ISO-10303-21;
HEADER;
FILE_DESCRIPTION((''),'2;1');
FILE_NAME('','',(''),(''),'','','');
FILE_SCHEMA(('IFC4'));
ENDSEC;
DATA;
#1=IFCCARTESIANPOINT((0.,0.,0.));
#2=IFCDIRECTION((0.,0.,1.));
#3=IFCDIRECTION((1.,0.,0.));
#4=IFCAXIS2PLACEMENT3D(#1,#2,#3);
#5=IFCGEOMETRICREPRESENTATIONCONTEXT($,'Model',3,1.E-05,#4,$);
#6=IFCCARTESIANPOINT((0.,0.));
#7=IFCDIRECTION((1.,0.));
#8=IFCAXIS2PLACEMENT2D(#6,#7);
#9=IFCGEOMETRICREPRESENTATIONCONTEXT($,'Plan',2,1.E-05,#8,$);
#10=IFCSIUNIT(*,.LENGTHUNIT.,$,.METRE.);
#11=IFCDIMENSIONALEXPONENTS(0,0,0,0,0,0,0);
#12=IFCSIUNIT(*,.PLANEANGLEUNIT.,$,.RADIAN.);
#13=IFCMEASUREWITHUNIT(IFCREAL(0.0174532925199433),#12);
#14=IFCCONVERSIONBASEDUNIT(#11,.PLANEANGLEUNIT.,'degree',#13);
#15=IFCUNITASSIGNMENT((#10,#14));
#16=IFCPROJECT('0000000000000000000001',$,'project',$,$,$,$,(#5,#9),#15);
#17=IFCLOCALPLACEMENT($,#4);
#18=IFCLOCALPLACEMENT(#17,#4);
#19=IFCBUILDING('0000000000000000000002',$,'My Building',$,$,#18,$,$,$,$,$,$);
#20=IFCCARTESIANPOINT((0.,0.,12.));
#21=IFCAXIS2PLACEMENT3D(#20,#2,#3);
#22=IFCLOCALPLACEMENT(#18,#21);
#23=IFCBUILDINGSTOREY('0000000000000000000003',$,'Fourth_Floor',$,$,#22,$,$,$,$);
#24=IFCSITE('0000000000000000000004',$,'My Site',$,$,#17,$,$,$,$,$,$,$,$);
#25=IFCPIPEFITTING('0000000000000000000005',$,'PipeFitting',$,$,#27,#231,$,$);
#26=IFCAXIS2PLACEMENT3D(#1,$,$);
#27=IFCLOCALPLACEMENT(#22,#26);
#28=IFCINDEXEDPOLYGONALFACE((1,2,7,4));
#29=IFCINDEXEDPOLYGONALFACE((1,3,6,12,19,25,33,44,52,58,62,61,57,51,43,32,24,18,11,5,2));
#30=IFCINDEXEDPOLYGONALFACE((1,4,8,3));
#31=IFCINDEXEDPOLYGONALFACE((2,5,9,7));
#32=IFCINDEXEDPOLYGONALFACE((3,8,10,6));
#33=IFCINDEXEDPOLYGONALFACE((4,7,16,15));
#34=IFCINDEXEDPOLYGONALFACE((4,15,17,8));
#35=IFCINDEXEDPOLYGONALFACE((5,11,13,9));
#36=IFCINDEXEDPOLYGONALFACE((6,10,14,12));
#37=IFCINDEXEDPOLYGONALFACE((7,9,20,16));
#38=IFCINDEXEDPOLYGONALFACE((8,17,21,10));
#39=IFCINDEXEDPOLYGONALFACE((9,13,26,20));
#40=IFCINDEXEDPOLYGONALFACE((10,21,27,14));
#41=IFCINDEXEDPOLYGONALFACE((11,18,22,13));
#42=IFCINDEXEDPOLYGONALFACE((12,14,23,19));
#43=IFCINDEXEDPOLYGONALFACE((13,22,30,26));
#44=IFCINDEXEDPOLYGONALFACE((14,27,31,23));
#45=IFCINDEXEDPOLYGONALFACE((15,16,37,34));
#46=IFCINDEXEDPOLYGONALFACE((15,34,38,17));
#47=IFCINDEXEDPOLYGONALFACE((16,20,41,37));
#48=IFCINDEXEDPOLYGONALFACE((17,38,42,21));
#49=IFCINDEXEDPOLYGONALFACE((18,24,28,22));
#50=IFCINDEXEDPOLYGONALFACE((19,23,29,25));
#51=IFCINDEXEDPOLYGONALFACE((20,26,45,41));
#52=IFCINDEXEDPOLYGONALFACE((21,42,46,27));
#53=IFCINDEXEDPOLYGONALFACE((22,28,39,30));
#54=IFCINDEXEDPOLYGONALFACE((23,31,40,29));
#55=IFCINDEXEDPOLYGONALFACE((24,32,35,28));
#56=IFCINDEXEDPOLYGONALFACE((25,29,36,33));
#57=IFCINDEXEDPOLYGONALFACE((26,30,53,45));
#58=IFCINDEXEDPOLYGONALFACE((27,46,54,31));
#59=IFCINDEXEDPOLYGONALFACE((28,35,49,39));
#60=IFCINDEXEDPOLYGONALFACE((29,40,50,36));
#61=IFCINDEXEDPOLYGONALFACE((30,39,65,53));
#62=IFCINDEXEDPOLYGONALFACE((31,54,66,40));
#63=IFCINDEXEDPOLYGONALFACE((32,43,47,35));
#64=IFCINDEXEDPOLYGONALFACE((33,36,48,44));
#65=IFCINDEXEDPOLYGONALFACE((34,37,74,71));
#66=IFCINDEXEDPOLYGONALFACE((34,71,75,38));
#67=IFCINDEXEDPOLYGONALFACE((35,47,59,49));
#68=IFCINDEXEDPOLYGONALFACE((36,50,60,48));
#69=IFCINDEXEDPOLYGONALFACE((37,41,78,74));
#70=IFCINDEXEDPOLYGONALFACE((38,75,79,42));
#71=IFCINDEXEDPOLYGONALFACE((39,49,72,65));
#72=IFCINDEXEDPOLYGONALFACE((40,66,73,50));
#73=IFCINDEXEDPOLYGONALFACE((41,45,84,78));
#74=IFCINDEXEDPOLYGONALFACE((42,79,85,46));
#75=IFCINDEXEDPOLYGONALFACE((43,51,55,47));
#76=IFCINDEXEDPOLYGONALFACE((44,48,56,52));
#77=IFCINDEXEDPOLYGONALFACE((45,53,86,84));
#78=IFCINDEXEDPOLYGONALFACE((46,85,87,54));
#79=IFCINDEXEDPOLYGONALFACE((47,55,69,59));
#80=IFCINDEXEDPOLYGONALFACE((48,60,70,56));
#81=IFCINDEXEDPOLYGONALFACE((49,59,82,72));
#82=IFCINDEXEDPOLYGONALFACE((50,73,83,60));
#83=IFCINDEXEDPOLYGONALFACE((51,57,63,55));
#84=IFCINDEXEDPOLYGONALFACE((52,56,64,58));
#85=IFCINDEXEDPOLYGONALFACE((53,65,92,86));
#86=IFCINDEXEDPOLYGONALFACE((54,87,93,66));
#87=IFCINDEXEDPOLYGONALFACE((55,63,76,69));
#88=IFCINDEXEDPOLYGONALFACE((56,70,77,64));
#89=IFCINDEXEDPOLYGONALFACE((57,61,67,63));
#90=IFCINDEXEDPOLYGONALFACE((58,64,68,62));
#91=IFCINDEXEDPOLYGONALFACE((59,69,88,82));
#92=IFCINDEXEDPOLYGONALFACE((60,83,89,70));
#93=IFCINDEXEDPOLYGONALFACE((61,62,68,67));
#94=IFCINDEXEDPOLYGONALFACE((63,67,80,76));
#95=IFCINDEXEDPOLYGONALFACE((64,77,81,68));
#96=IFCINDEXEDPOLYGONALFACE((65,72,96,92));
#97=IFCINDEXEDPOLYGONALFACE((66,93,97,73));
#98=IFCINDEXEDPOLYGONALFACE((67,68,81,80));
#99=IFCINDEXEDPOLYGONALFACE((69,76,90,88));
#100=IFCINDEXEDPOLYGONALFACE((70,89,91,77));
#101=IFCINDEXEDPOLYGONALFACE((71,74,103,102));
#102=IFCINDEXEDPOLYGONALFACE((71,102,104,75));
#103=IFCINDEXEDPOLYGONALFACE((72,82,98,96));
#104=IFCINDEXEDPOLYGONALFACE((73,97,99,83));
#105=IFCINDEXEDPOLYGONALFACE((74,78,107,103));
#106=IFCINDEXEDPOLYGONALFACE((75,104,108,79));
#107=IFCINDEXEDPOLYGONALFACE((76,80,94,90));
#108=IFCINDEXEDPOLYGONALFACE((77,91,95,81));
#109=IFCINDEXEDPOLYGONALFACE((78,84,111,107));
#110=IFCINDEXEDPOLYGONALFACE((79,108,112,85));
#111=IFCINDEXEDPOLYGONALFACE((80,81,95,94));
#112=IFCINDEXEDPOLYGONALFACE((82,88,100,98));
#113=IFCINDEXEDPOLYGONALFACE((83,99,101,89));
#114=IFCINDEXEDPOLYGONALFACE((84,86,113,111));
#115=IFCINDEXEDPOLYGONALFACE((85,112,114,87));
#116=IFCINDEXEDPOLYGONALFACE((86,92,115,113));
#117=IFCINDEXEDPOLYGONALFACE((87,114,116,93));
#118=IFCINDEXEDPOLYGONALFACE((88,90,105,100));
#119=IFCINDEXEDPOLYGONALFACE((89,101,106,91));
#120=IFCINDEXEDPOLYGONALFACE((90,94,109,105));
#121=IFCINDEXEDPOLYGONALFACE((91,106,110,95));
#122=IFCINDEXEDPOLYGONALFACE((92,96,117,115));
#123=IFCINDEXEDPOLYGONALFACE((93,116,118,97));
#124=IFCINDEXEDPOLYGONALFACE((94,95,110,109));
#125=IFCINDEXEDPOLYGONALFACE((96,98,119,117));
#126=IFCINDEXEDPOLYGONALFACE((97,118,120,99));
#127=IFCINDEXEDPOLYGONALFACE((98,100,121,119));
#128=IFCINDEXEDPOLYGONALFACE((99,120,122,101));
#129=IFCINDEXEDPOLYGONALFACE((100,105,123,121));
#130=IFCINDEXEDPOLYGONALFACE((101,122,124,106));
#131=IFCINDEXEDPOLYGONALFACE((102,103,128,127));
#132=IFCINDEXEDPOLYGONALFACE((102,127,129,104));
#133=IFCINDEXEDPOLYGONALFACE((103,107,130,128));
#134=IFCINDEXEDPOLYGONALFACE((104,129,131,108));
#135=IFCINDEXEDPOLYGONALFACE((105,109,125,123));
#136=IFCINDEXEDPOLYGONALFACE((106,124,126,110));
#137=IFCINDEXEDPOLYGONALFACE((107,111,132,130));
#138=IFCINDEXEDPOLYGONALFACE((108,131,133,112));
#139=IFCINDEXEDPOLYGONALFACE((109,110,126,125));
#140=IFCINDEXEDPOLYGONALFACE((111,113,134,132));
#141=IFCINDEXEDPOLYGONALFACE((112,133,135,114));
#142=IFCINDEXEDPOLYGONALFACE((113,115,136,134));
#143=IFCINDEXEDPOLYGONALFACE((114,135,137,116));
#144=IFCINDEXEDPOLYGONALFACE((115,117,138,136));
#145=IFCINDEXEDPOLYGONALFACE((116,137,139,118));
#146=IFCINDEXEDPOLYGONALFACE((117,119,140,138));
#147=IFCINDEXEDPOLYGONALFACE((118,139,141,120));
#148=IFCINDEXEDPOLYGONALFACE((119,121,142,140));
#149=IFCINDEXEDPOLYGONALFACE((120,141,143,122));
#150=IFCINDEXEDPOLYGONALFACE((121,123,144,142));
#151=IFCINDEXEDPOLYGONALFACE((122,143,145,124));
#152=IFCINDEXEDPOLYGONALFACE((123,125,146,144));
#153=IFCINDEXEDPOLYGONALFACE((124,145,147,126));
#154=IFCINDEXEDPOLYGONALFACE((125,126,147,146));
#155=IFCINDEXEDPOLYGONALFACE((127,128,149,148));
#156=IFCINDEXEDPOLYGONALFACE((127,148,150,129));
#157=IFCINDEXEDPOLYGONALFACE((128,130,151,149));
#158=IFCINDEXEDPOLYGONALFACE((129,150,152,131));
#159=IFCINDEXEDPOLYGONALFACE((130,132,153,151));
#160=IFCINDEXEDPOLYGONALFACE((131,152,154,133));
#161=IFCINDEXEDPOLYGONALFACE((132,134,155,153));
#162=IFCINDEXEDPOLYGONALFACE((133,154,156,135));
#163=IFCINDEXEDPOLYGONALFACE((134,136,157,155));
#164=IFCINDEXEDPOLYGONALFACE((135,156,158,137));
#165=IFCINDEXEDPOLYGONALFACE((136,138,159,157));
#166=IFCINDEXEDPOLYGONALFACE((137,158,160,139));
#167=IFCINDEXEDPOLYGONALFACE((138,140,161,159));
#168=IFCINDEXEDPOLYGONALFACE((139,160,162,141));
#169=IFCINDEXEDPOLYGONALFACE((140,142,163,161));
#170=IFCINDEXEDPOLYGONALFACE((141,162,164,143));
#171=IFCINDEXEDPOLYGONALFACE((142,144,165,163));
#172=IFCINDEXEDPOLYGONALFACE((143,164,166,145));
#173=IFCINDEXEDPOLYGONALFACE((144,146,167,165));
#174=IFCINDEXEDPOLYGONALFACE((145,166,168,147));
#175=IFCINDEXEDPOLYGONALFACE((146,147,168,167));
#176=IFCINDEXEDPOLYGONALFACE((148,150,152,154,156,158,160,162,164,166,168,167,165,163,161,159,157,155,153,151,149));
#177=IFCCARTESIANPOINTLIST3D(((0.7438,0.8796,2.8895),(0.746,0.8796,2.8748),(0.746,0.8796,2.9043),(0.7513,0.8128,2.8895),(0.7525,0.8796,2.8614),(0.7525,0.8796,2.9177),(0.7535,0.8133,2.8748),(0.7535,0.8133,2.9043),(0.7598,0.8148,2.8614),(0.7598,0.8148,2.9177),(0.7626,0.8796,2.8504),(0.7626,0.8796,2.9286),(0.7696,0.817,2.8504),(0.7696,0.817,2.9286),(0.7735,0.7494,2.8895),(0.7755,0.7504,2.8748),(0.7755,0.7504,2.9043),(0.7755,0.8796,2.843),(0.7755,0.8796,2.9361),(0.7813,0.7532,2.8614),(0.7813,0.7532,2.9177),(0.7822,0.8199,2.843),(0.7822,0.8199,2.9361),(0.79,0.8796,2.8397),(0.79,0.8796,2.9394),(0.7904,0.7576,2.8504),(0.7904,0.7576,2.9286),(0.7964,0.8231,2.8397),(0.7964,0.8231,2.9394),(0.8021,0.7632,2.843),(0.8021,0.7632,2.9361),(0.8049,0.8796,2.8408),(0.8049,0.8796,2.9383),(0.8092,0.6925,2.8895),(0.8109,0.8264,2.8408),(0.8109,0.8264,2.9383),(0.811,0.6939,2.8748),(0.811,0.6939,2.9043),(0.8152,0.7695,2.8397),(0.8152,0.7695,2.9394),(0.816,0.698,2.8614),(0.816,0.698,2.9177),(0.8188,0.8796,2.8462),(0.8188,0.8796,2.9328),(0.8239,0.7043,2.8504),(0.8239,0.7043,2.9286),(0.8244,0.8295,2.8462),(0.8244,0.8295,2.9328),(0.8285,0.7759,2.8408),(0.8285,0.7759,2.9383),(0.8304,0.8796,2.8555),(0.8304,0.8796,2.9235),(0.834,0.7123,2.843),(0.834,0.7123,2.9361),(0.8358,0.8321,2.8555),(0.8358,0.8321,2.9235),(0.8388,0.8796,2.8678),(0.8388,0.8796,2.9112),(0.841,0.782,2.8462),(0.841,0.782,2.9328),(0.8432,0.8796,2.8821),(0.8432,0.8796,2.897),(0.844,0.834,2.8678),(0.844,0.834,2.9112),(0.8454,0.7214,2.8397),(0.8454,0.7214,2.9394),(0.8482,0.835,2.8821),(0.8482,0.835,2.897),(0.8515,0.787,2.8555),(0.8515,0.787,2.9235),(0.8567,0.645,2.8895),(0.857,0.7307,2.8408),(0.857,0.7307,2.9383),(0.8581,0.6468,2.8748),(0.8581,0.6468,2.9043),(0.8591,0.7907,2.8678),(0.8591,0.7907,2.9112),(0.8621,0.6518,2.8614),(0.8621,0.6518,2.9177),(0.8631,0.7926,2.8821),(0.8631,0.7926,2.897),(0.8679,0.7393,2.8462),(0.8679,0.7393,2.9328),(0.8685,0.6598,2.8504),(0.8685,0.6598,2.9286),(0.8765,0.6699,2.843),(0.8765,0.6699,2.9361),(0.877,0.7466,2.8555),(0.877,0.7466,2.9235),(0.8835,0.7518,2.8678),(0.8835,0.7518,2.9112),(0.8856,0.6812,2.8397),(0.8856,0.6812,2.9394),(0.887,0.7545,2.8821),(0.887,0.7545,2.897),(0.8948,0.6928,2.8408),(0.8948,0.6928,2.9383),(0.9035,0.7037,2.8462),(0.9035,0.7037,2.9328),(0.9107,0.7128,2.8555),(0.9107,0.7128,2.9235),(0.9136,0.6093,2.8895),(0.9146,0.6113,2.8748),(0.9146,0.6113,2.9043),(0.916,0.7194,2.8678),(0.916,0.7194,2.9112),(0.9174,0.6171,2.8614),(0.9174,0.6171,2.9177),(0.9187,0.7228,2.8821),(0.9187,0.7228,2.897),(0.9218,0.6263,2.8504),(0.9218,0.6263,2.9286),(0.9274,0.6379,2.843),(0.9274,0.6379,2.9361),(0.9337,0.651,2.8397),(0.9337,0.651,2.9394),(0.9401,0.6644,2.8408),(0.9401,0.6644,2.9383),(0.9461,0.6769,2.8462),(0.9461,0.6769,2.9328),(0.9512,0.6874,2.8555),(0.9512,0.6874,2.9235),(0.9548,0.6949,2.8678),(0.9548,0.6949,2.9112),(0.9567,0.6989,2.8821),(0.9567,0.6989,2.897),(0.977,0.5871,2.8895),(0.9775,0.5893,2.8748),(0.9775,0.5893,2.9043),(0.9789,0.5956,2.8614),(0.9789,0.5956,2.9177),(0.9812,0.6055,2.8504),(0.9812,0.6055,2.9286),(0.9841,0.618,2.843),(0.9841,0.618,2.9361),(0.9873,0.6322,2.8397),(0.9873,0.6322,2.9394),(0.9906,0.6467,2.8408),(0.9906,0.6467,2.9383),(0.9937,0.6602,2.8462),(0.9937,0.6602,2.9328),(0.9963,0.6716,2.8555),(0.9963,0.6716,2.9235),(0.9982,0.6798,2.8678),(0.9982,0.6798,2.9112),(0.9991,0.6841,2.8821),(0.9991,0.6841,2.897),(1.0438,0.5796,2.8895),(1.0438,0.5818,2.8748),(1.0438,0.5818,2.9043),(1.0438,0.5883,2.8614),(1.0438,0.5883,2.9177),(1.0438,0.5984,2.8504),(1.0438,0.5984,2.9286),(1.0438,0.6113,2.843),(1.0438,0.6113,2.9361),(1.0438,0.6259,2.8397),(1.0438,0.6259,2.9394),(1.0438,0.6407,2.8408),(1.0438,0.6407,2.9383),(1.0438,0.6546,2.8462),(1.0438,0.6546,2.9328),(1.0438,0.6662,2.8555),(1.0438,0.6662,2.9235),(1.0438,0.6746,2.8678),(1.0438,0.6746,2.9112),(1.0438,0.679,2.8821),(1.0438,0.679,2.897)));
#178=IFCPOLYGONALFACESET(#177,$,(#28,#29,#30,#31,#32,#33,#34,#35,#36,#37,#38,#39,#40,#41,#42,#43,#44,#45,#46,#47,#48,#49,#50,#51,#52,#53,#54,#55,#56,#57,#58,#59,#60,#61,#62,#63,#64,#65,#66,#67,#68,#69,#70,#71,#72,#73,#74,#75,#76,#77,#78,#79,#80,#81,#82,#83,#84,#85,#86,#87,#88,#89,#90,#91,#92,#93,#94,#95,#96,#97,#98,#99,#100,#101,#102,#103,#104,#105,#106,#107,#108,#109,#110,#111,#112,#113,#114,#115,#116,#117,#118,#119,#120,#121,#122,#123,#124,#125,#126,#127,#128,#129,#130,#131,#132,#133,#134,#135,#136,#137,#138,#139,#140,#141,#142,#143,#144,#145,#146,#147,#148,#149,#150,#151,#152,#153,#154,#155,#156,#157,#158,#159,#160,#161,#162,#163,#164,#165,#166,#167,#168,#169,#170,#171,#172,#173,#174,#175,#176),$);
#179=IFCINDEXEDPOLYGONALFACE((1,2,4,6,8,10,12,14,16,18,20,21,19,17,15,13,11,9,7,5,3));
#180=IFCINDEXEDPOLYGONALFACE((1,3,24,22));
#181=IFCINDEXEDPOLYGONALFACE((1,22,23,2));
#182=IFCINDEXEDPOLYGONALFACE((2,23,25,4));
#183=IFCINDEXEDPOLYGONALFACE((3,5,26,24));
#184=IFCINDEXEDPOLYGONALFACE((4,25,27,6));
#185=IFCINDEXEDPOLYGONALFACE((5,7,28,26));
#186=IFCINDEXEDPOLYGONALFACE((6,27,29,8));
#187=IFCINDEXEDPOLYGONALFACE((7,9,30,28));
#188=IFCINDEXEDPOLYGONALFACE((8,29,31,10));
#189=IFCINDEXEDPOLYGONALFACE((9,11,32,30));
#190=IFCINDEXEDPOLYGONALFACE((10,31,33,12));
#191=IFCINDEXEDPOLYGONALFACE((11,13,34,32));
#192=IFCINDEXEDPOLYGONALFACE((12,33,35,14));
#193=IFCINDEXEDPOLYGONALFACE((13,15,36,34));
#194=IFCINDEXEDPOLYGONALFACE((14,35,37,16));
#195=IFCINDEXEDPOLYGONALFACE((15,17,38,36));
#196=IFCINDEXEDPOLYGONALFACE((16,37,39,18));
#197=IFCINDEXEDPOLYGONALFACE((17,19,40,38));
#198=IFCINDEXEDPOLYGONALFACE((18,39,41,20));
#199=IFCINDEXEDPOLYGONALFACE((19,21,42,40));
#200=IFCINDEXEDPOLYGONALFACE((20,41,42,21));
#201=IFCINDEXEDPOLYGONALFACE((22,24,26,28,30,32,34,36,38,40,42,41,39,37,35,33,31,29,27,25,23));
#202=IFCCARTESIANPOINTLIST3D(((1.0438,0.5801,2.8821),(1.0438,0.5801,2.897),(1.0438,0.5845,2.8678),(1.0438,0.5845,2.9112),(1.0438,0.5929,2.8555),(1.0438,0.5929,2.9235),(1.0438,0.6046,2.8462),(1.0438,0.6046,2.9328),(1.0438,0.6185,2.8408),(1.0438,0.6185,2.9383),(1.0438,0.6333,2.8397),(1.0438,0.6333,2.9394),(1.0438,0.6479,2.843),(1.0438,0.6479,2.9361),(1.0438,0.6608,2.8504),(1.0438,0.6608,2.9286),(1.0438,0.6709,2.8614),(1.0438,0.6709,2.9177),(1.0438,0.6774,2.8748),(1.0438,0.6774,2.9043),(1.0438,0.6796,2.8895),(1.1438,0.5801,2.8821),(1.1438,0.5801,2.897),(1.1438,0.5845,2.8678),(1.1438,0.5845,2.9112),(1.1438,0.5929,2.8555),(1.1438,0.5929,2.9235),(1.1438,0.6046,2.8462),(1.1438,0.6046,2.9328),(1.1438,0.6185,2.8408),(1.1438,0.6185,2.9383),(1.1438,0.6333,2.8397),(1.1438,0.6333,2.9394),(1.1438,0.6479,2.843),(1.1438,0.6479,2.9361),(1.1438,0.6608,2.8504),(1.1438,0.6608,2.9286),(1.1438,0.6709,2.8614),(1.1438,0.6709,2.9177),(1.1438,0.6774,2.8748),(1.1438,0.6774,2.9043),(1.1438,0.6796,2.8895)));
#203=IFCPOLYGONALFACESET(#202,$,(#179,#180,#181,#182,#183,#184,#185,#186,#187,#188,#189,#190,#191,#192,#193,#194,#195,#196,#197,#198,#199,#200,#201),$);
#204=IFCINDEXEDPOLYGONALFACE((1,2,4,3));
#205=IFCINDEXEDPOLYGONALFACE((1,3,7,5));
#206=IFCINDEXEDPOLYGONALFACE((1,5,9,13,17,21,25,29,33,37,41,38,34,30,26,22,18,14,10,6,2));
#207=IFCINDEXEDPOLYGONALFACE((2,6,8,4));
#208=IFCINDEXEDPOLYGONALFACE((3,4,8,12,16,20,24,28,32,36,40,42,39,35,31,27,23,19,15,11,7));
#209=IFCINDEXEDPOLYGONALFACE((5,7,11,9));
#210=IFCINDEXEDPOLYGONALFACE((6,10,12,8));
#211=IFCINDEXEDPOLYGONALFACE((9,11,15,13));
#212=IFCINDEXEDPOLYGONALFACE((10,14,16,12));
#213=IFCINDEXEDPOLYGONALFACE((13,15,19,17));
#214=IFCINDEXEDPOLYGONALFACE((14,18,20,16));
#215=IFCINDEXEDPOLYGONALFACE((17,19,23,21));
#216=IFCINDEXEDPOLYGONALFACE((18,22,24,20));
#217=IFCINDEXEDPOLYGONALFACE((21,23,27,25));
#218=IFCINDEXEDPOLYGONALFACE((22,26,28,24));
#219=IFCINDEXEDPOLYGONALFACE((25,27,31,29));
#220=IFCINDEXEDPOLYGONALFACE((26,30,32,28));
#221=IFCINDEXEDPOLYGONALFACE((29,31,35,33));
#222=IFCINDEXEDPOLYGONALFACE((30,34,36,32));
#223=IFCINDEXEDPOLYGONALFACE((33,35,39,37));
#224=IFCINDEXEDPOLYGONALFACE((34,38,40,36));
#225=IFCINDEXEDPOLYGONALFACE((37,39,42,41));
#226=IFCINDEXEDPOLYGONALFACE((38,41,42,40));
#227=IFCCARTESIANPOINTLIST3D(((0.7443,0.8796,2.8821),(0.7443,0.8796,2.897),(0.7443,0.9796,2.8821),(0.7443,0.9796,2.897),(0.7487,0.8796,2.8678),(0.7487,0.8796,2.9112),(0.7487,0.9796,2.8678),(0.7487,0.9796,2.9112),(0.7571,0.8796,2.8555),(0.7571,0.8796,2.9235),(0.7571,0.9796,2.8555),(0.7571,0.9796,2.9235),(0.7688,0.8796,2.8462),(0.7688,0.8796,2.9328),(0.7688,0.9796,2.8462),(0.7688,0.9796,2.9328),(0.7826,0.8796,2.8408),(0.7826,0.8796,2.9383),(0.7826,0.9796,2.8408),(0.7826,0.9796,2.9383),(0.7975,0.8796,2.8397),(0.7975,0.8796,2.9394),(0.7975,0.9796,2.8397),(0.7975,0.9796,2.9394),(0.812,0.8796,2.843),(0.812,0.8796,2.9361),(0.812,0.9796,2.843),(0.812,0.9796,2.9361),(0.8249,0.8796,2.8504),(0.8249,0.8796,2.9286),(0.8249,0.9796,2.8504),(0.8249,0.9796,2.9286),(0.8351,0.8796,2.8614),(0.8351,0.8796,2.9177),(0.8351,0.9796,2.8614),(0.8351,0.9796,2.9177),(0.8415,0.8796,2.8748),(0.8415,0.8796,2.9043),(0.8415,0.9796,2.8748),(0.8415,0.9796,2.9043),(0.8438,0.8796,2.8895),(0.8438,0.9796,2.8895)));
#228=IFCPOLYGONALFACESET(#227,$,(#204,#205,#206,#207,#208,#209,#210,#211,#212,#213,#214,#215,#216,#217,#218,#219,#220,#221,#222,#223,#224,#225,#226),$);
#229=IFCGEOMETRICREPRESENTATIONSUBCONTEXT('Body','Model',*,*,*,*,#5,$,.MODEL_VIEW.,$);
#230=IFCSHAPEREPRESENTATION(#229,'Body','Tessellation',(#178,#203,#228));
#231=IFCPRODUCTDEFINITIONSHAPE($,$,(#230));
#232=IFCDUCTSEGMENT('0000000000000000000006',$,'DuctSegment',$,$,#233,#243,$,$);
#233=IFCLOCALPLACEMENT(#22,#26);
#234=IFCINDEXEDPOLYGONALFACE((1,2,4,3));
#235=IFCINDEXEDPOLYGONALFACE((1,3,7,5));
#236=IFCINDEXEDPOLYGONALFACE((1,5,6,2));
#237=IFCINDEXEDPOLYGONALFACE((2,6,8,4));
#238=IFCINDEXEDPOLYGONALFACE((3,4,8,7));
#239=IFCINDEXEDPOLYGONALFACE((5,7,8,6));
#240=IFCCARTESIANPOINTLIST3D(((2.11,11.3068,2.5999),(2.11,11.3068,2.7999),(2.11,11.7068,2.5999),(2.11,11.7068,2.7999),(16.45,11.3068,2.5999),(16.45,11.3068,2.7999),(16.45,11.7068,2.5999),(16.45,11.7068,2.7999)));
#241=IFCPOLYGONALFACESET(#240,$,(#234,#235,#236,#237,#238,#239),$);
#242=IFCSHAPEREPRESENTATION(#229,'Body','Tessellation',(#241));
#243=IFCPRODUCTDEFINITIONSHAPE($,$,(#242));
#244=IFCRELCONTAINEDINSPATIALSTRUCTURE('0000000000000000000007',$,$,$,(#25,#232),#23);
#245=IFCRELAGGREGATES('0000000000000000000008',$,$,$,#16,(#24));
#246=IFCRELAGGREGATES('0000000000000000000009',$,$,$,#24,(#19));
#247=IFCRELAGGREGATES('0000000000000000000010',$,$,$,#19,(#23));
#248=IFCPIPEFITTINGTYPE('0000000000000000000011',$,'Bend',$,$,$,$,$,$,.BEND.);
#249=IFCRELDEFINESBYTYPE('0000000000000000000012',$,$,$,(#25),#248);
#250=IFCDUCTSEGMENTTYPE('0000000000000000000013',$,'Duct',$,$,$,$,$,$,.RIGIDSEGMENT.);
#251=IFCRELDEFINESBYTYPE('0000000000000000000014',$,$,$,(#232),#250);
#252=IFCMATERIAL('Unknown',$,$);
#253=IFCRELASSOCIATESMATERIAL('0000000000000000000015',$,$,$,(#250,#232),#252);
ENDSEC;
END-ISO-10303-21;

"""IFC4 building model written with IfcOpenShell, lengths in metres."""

from ifc_helpers import new_model, entity, si_unit, converted_unit, frame, origin_with_axes, origin_2d_with_axis, place, context, subcontext, project, spatial, rectangle, circle, extrude, source, transform, mapped, material, material_profile, profile_set, profile_usage, type_object, type_shapes, element, save


model = new_model("IFC4")

# Units and contexts
model_context = context("Model", 3, precision=1e-05, world=origin_with_axes())
plan_context = context("Plan", 2, precision=1e-05, world=origin_2d_with_axis())
body_context_1 = subcontext(model_context, "Body", "Model", "MODEL_VIEW")
ifc_project = project(units=[si_unit("LENGTHUNIT", "METRE"), converted_unit("PLANEANGLEUNIT", "degree", entity("IfcReal", 0.0174532925199433), si_unit("PLANEANGLEUNIT", "RADIAN"), dimensions=[0, 0, 0, 0, 0, 0, 0])], contexts=[model_context, plan_context])

# Site, building, storey
site_placement = place(None, origin_with_axes())
site = spatial("IfcSite", under=ifc_project, at=site_placement, Name="My Site")
building_placement = place(site_placement, origin_with_axes())
building = spatial("IfcBuilding", under=site, at=building_placement, Name="My Building")
storey_placement = place(building_placement, frame((0.0, 0.0, 12.0), z_axis=(0.0, 0.0, 1.0), x_axis=(1.0, 0.0, 0.0)))
storey = spatial("IfcBuildingStorey", under=building, at=storey_placement, Name="Fourth_Floor")

# Shared definitions
ifc_material = material(Name="Unknown")

# Pipe fitting
pipe_fitting_type = type_object("IfcPipeFittingType", Name="Bend", PredefinedType="BEND")
shared_shape_1 = source(origin_with_axes(), body_context_1, "Body", "SolidModel", [
    entity("IfcSweptDiskSolid", entity("IfcIndexedPolyCurve", entity("IfcCartesianPointList3D", [[0.0, 0.0, -0.1], [0.0732, 0.0, -0.2768], [0.25, 0.0, -0.35]]), [entity("IfcArcIndex", [1, 2, 3])]), 0.05),
    extrude(circle(Radius=0.05), origin_with_axes(), (0.0, 0.0, -1.0), 0.1),
    extrude(circle(Radius=0.05), frame((0.25, 0.0, -0.35), z_axis=(1.0, 0.0, 0.0), x_axis=(0.0, 0.0, 1.0)), (0.0, 0.0, 1.0), 0.1),
])
type_shapes(pipe_fitting_type, [shared_shape_1])
pipe_fitting_placement = place(storey_placement, frame((1.1438, 0.6296, 2.8895), z_axis=(1.0, 0.000001, 0.0), x_axis=(-0.000001, 1.0, 0.0)))
element("IfcPipeFitting", 1, at=pipe_fitting_placement, inside=storey, type_object=pipe_fitting_type, Name="PipeFitting", context=body_context_1, shape_type="MappedRepresentation", body=[
    mapped(shared_shape_1, transform((0.0, 0.0, 0.0), x_axis=(1.0, 0.0, 0.0), y_axis=(0.0, 1.0, 0.0), z_axis=(0.0, 0.0, 1.0), scale=1.0)),
])

# Duct segment
ifc_material_profile_1 = material_profile(ifc_material, rectangle(XDim=0.4, YDim=0.2))
ifc_profile_set_1 = profile_set([ifc_material_profile_1])
ifc_profile_usage_1 = profile_usage(ifc_profile_set_1, cardinal=5)
duct_segment_type = type_object("IfcDuctSegmentType", Name="Duct", PredefinedType="RIGIDSEGMENT", material=ifc_profile_set_1)
duct_segment_placement = place(storey_placement, frame((2.11, 11.5068, 2.6999), z_axis=(1.0, 0.0, 0.0), x_axis=(0.0, 1.0, 0.0)))
element("IfcDuctSegment", 2, at=duct_segment_placement, inside=storey, type_object=duct_segment_type, material=ifc_profile_usage_1, Name="DuctSegment", context=body_context_1, shape_type="SweptSolid", body=[
    extrude(rectangle(XDim=0.4, YDim=0.2), origin_with_axes(), (0.0, 0.0, 1.0), 14.3399),
])

save(model, "model.ifc")
